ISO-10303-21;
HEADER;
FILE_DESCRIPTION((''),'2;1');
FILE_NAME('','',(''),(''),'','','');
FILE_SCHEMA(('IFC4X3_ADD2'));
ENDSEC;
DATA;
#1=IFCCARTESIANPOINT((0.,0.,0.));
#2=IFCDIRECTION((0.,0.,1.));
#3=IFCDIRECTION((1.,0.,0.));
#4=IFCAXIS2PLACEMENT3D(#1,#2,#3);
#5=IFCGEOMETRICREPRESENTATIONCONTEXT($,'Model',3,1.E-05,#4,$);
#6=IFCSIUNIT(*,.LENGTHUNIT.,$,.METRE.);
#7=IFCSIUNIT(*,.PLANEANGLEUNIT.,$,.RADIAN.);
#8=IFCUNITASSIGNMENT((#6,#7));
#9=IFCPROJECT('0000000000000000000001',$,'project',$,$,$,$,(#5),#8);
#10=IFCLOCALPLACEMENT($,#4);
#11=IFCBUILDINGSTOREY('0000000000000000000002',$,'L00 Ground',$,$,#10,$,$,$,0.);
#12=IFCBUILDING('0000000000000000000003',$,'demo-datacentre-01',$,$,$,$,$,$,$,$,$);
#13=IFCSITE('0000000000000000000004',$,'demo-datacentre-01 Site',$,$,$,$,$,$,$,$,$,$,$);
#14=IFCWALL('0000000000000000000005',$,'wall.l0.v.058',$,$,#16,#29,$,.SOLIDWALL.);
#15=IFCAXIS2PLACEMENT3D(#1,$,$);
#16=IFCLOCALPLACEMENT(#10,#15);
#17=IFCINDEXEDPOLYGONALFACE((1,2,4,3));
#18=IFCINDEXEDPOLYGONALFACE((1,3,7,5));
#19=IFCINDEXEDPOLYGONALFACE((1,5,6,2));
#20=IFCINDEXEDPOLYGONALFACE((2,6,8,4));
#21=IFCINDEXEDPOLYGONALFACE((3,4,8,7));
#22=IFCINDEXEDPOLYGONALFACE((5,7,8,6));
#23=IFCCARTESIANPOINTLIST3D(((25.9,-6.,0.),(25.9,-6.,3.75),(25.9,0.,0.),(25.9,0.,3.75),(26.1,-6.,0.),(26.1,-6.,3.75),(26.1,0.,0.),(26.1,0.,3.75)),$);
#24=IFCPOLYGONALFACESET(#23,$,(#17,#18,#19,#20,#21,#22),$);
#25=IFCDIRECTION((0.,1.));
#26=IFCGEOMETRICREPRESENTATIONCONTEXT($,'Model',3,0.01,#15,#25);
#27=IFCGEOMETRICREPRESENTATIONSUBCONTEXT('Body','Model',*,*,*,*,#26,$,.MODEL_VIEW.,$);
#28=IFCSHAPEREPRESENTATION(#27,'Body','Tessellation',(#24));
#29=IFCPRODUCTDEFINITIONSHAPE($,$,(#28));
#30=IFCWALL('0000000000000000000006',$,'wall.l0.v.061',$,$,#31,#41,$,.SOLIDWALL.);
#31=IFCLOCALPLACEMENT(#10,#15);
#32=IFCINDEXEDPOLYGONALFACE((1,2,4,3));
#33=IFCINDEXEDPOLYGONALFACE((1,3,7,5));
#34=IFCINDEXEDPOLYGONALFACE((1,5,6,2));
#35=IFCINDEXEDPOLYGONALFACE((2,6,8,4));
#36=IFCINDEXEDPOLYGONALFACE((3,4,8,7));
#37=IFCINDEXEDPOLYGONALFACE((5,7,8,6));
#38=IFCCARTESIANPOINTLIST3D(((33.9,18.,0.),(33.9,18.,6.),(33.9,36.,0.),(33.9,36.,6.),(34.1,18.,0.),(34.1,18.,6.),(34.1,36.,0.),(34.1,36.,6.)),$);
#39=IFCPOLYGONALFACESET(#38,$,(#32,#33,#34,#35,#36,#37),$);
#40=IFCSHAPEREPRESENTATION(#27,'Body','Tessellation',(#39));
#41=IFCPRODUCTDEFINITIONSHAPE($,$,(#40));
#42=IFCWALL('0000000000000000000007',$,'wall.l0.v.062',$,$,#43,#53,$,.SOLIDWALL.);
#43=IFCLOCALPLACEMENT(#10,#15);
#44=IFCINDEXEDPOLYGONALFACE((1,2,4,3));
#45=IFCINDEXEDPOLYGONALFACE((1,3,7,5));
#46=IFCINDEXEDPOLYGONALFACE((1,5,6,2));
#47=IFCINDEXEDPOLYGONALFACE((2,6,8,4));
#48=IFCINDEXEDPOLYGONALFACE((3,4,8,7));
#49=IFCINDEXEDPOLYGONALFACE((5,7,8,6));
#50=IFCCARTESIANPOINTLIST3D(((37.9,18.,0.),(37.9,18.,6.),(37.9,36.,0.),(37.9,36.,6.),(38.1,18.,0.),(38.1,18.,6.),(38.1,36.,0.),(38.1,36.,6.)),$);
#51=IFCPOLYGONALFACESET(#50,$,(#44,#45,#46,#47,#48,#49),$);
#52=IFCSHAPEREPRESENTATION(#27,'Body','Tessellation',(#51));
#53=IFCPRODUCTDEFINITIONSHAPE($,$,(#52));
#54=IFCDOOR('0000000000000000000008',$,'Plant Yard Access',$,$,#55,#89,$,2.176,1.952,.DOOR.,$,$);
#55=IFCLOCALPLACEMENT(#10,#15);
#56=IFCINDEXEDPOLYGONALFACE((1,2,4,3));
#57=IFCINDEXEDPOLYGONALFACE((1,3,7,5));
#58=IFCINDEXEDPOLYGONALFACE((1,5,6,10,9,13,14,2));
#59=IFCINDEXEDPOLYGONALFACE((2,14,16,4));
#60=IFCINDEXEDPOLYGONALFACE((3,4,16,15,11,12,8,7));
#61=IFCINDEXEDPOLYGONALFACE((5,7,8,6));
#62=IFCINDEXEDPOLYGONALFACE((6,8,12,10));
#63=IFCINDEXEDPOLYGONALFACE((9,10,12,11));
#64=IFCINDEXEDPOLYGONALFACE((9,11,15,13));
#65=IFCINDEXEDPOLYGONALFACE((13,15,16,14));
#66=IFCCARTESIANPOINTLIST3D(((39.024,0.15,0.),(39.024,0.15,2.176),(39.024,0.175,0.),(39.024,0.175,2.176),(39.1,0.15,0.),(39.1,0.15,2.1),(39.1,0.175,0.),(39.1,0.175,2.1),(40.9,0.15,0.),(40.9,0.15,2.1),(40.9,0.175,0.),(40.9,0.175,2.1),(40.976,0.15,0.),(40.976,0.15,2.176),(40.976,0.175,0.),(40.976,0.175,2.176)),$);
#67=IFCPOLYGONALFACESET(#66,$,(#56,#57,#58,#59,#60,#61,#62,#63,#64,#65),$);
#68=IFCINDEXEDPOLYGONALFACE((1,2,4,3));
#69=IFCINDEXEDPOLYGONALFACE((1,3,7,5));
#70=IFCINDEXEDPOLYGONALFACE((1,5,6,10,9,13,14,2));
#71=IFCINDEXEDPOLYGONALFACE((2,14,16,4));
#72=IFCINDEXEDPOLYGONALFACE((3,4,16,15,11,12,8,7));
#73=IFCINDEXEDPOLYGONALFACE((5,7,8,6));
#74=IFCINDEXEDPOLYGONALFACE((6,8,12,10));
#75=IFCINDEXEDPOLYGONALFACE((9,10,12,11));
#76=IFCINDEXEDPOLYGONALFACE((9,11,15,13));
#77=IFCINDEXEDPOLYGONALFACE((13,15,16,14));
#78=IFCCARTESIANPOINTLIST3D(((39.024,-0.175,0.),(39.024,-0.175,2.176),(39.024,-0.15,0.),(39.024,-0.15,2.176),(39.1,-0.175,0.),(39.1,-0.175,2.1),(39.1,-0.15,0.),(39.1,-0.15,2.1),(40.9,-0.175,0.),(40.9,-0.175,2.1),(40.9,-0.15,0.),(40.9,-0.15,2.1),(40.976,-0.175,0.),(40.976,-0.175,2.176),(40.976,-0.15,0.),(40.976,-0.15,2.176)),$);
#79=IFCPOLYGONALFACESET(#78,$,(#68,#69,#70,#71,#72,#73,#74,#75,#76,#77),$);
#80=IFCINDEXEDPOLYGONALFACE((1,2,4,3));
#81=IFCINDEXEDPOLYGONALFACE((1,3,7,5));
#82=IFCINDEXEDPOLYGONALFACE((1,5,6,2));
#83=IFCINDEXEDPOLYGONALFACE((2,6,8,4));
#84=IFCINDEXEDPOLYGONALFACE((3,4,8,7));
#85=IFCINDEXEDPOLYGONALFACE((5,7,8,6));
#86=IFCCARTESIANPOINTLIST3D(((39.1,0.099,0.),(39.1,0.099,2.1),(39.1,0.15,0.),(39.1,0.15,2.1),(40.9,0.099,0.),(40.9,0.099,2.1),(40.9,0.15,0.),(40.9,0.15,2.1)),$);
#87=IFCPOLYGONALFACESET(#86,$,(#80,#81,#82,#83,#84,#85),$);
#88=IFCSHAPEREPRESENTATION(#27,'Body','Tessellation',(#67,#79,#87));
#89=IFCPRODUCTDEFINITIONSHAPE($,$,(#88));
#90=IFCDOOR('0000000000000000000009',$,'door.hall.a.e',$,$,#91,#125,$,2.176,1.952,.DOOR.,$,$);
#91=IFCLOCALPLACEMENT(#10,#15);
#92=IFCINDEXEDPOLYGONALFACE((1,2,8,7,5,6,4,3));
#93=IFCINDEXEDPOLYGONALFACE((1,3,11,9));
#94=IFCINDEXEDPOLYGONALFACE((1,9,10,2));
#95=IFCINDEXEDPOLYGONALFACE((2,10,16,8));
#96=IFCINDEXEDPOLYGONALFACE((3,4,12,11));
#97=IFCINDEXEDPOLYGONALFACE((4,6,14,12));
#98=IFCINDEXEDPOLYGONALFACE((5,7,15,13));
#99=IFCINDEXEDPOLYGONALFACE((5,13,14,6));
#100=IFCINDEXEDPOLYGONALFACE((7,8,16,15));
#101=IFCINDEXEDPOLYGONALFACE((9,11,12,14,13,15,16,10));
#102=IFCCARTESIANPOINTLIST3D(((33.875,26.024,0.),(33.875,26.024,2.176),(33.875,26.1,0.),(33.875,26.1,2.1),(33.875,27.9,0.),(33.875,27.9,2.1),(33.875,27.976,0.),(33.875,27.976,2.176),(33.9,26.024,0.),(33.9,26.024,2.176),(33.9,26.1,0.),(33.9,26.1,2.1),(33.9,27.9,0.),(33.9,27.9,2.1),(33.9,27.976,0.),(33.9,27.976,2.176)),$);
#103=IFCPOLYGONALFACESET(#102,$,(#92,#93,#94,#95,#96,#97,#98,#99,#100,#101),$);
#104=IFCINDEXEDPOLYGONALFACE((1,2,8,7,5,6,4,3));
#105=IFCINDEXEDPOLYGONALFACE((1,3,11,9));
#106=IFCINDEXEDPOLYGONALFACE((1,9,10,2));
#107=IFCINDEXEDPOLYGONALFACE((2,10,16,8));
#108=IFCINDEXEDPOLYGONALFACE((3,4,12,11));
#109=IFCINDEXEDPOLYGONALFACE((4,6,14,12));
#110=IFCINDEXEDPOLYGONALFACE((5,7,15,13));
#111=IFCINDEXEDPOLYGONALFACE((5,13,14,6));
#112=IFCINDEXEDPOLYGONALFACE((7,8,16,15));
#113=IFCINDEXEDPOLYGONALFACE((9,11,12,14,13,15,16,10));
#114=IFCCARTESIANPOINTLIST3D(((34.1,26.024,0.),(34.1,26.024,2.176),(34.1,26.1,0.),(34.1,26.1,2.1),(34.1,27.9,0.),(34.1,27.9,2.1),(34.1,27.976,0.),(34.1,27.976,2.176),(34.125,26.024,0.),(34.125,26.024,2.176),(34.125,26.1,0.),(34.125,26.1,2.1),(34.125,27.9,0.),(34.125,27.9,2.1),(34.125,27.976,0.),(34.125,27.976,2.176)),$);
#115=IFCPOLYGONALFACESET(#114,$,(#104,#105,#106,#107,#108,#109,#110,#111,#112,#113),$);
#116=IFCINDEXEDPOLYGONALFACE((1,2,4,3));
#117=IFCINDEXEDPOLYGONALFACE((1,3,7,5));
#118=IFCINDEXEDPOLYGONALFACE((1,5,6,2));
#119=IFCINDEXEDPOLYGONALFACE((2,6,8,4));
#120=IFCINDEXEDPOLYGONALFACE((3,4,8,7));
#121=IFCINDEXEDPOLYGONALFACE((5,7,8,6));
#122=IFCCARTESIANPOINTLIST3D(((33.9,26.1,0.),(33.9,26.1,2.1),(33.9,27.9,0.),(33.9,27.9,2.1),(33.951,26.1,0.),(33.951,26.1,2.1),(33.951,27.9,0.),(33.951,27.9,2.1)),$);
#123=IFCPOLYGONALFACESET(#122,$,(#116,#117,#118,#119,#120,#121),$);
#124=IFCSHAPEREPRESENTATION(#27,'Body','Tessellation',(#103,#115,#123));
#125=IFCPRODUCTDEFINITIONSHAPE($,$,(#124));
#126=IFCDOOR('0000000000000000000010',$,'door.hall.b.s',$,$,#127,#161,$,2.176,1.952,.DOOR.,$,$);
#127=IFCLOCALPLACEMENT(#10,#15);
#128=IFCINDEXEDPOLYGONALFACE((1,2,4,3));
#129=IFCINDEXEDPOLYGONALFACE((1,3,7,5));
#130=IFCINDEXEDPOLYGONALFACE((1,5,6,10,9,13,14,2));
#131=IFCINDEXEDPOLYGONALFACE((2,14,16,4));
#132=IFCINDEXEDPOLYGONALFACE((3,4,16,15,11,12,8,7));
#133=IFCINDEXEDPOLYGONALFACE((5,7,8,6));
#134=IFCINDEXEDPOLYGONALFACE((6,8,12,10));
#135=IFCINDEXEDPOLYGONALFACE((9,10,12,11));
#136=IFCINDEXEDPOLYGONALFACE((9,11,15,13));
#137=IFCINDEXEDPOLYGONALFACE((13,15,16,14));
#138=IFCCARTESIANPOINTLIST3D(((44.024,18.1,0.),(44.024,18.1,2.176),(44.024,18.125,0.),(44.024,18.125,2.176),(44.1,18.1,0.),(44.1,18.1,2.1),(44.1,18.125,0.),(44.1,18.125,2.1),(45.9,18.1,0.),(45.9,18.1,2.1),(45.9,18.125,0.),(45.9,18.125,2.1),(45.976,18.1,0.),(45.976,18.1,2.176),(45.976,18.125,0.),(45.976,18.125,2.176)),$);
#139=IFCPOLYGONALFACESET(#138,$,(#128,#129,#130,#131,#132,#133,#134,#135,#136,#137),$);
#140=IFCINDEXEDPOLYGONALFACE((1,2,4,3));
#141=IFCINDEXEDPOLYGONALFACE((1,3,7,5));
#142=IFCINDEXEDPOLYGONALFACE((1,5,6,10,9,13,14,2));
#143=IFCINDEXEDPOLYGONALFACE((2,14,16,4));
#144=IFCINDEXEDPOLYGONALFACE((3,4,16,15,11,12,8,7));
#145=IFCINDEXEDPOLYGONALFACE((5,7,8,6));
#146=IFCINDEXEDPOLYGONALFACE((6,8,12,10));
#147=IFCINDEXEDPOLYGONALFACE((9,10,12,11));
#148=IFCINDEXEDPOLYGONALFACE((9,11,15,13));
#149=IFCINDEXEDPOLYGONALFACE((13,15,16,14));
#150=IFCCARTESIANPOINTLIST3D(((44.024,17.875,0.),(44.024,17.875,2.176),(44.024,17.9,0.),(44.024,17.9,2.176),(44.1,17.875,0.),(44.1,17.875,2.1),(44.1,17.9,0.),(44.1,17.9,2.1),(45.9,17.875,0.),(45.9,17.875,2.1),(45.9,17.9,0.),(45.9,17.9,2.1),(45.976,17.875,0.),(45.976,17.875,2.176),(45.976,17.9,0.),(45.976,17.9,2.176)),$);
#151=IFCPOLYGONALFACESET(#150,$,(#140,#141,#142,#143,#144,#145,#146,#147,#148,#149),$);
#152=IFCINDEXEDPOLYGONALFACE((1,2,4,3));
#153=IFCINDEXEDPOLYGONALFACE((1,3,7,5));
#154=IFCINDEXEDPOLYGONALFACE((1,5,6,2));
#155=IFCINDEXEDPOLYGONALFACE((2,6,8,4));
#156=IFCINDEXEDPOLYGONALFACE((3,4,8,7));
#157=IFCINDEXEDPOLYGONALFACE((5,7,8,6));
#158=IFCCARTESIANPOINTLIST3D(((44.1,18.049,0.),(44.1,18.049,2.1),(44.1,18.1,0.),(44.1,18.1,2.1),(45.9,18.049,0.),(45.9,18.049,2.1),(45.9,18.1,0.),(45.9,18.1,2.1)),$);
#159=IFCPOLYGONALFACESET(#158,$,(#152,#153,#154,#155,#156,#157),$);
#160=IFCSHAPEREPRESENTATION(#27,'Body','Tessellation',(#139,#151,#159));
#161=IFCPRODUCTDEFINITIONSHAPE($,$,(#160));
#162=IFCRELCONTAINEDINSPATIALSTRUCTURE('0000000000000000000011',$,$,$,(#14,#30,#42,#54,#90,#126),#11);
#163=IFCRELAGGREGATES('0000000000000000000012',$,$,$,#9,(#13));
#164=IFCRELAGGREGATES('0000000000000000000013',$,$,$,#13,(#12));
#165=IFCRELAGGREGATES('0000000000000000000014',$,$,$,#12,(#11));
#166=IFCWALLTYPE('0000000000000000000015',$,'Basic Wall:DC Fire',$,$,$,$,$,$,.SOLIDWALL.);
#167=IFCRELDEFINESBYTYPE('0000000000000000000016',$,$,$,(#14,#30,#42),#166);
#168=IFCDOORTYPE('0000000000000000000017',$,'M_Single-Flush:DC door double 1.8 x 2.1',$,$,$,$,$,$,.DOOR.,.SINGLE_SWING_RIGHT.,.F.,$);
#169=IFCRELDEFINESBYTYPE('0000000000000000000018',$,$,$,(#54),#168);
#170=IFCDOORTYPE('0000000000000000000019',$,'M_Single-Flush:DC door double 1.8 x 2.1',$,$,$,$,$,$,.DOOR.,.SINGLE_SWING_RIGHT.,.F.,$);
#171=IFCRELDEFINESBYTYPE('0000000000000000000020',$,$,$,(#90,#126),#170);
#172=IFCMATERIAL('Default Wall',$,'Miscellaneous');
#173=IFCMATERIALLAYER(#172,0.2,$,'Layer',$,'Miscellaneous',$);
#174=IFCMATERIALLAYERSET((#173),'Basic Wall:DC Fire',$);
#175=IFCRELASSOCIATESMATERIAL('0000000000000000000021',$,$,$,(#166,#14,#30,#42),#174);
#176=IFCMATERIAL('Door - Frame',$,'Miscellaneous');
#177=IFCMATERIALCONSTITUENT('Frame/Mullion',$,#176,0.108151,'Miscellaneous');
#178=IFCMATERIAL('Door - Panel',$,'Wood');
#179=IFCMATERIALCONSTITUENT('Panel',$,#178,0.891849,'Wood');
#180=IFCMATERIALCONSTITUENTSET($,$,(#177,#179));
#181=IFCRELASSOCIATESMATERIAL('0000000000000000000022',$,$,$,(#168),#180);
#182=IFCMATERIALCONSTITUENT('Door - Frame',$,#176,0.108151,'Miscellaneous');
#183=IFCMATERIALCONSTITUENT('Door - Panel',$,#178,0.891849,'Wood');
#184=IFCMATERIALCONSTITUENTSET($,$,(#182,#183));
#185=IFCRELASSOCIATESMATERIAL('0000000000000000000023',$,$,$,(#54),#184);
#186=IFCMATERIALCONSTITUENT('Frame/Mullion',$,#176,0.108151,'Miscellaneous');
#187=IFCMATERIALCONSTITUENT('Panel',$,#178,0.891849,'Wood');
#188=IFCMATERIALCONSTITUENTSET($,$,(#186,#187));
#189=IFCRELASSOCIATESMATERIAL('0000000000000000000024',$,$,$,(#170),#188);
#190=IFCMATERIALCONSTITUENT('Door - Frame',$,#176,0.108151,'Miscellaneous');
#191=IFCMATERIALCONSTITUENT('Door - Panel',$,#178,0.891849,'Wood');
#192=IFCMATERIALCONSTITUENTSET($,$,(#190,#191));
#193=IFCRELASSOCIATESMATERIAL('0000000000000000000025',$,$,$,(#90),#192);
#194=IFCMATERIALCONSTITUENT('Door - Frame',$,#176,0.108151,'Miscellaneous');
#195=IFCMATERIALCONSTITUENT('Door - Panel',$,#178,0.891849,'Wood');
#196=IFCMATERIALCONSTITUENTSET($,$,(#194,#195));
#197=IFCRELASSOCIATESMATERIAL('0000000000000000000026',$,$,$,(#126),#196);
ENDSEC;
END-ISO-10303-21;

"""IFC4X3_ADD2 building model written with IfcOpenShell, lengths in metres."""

from ifc_helpers import new_model, si_unit, direction, frame, frame_2d, origin, origin_with_axes, place, context, subcontext, project, spatial, polyline, rectangle, outline, extrude, source, transform, mapped, material, layer, layer_set, constituent, constituent_set, type_object, type_shapes, element, save


model = new_model("IFC4X3_ADD2")

# Units and contexts
model_context_1 = context("Model", 3, precision=0.01, world=origin(), true_north=direction((0.0, 1.0)))
model_context_2 = context("Model", 3, precision=1e-05, world=origin_with_axes())
body_context = subcontext(model_context_1, "Body", "Model", "MODEL_VIEW")
ifc_project = project(units=[si_unit("LENGTHUNIT", "METRE"), si_unit("PLANEANGLEUNIT", "RADIAN")], contexts=[model_context_2])

# Site, building, storey
site = spatial("IfcSite", under=ifc_project, Name="demo-datacentre-01 Site")
building = spatial("IfcBuilding", under=site, Name="demo-datacentre-01")
storey_placement = place(None, origin_with_axes())
storey = spatial("IfcBuildingStorey", under=building, at=storey_placement, Name="L00 Ground", Elevation=0.0)

# Walls
ifc_material_1 = material(Name="Default Wall", Category="Miscellaneous")
placement_1 = place(None, origin())
placement_2 = place(placement_1, origin())
placement_3 = place(placement_2, origin())
ifc_layer_1 = layer(ifc_material_1, 0.2, Name="Layer", Category="Miscellaneous")
ifc_layer_set_1 = layer_set([ifc_layer_1], Name="Basic Wall:DC Fire")
wall_type_1 = type_object("IfcWallType", Name="Basic Wall:DC Fire", PredefinedType="SOLIDWALL", material=ifc_layer_set_1)
wall_1_placement = place(placement_3, frame((26.0, -6.0, 0.0), z_axis=(0.0, 0.0, 1.0), x_axis=(0.0, 1.0, 0.0)))
element("IfcWall", 1, at=wall_1_placement, inside=storey, type_object=wall_type_1, material=ifc_layer_set_1, Name="wall.l0.v.058", PredefinedType="SOLIDWALL", context=body_context, shape_type="SweptSolid", body=[
    extrude(rectangle(XDim=6.0, YDim=0.2, at=frame_2d((3.0, 0.0), x_axis=(-1.0, 0.0))), origin(), (0.0, 0.0, 1.0), 3.75),
])
for number, where, z_axis, x_axis, name in (
    (2, (34.0, 18.0, 0.0), (0.0, 0.0, 1.0), (0.0, 1.0, 0.0), "wall.l0.v.061"),
    (3, (38.0, 18.0, 0.0), (0.0, 0.0, 1.0), (0.0, 1.0, 0.0), "wall.l0.v.062"),
):
    element("IfcWall", number, at=place(placement_3, frame(where, z_axis=z_axis, x_axis=x_axis)), inside=storey, type_object=wall_type_1, material=ifc_layer_set_1, Name=name, PredefinedType="SOLIDWALL", context=body_context, shape_type="SweptSolid", body=[
        extrude(rectangle(XDim=18.0, YDim=0.2, at=frame_2d((9.0, 0.0), x_axis=(-1.0, 0.0))), origin(), (0.0, 0.0, 1.0), 6.0),
    ])

# Doors
ifc_material_2 = material(Name="Door - Frame", Category="Miscellaneous")
ifc_constituent_1 = constituent(ifc_material_2, Name="Door - Frame", Category="Miscellaneous", fraction=0.108151)
ifc_material_3 = material(Name="Door - Panel", Category="Wood")
ifc_constituent_2 = constituent(ifc_material_3, Name="Door - Panel", Category="Wood", fraction=0.891849)
ifc_constituent_set_1 = constituent_set(constituents=[ifc_constituent_1, ifc_constituent_2])
ifc_constituent_3 = constituent(ifc_material_2, Name="Frame/Mullion", Category="Miscellaneous", fraction=0.108151)
ifc_constituent_4 = constituent(ifc_material_3, Name="Panel", Category="Wood", fraction=0.891849)
ifc_constituent_set_2 = constituent_set(constituents=[ifc_constituent_3, ifc_constituent_4])
door_type_1 = type_object("IfcDoorType", Name="M_Single-Flush:DC door double 1.8 x 2.1", OperationType="SINGLE_SWING_RIGHT", ParameterTakesPrecedence=False, PredefinedType="DOOR", material=ifc_constituent_set_2)
shared_shape_1 = source(origin(), body_context, "Body", "SweptSolid", [
    extrude(outline(polyline([(-0.976, -1.107), (0.976, -1.107), (0.976, 1.069), (0.9, 1.069), (0.9, -1.031), (-0.9, -1.031), (-0.9, 1.069), (-0.976, 1.069), (-0.976, -1.107)])), frame((0.9, 0.3, 1.069), z_axis=(0.0, 1.0, 0.0), x_axis=(1.0, 0.0, 0.0)), (0.0, 0.0, 1.0), 0.025),
    extrude(outline(polyline([(-1.107, -0.976), (1.069, -0.976), (1.069, -0.9), (-1.031, -0.9), (-1.031, 0.9), (1.069, 0.9), (1.069, 0.976), (-1.107, 0.976), (-1.107, -0.976)])), frame((0.9, -0.025, 1.069), z_axis=(0.0, 1.0, 0.0), x_axis=(0.0, 0.0, -1.0)), (0.0, 0.0, 1.0), 0.025),
    extrude(rectangle(XDim=0.051, YDim=1.8, at=frame_2d((0.0, 0.0), x_axis=(1.0, 0.0))), frame((0.9, 0.2745, 0.0), z_axis=(0.0, 0.0, 1.0), x_axis=(0.0, 1.0, 0.0)), (0.0, 0.0, 1.0), 2.1),
])
type_shapes(door_type_1, [shared_shape_1])
door_1_placement = place(placement_3, frame((39.1, -0.15, 0.0)))
element("IfcDoor", 4, at=door_1_placement, inside=storey, type_object=door_type_1, material=ifc_constituent_set_1, Name="Plant Yard Access", OverallHeight=2.176, OverallWidth=1.952, PredefinedType="DOOR", context=body_context, shape_type="MappedRepresentation", body=[
    mapped(shared_shape_1, transform((0.0, 0.0, 0.0), scale=1.0)),
])
ifc_constituent_5 = constituent(ifc_material_2, Name="Door - Frame", Category="Miscellaneous", fraction=0.108151)
ifc_constituent_6 = constituent(ifc_material_3, Name="Door - Panel", Category="Wood", fraction=0.891849)
ifc_constituent_set_3 = constituent_set(constituents=[ifc_constituent_5, ifc_constituent_6])
ifc_constituent_7 = constituent(ifc_material_2, Name="Frame/Mullion", Category="Miscellaneous", fraction=0.108151)
ifc_constituent_8 = constituent(ifc_material_3, Name="Panel", Category="Wood", fraction=0.891849)
ifc_constituent_set_4 = constituent_set(constituents=[ifc_constituent_7, ifc_constituent_8])
door_type_2 = type_object("IfcDoorType", Name="M_Single-Flush:DC door double 1.8 x 2.1", OperationType="SINGLE_SWING_RIGHT", ParameterTakesPrecedence=False, PredefinedType="DOOR", material=ifc_constituent_set_4)
shared_shape_2 = source(origin(), body_context, "Body", "SweptSolid", [
    extrude(outline(polyline([(-0.976, -1.107), (0.976, -1.107), (0.976, 1.069), (0.9, 1.069), (0.9, -1.031), (-0.9, -1.031), (-0.9, 1.069), (-0.976, 1.069), (-0.976, -1.107)])), frame((0.9, 0.2, 1.069), z_axis=(0.0, 1.0, 0.0), x_axis=(1.0, 0.0, 0.0)), (0.0, 0.0, 1.0), 0.025),
    extrude(outline(polyline([(-1.107, -0.976), (1.069, -0.976), (1.069, -0.9), (-1.031, -0.9), (-1.031, 0.9), (1.069, 0.9), (1.069, 0.976), (-1.107, 0.976), (-1.107, -0.976)])), frame((0.9, -0.025, 1.069), z_axis=(0.0, 1.0, 0.0), x_axis=(0.0, 0.0, -1.0)), (0.0, 0.0, 1.0), 0.025),
    extrude(rectangle(XDim=0.051, YDim=1.8, at=frame_2d((0.0, 0.0), x_axis=(1.0, 0.0))), frame((0.9, 0.1745, 0.0), z_axis=(0.0, 0.0, 1.0), x_axis=(0.0, 1.0, 0.0)), (0.0, 0.0, 1.0), 2.1),
])
type_shapes(door_type_2, [shared_shape_2])
door_2_placement = place(placement_3, frame((34.1, 26.1, 0.0), z_axis=(0.0, 0.0, 1.0), x_axis=(0.0, 1.0, 0.0)))
element("IfcDoor", 5, at=door_2_placement, inside=storey, type_object=door_type_2, material=ifc_constituent_set_3, Name="door.hall.a.e", OverallHeight=2.176, OverallWidth=1.952, PredefinedType="DOOR", context=body_context, shape_type="MappedRepresentation", body=[
    mapped(shared_shape_2, transform((0.0, 0.0, 0.0), scale=1.0)),
])
ifc_constituent_9 = constituent(ifc_material_2, Name="Door - Frame", Category="Miscellaneous", fraction=0.108151)
ifc_constituent_10 = constituent(ifc_material_3, Name="Door - Panel", Category="Wood", fraction=0.891849)
ifc_constituent_set_5 = constituent_set(constituents=[ifc_constituent_9, ifc_constituent_10])
door_3_placement = place(placement_3, frame((44.1, 17.9, 0.0)))
element("IfcDoor", 6, at=door_3_placement, inside=storey, type_object=door_type_2, material=ifc_constituent_set_5, Name="door.hall.b.s", OverallHeight=2.176, OverallWidth=1.952, PredefinedType="DOOR", context=body_context, shape_type="MappedRepresentation", body=[
    mapped(shared_shape_2, transform((0.0, 0.0, 0.0), scale=1.0)),
])

save(model, "model.ifc")
